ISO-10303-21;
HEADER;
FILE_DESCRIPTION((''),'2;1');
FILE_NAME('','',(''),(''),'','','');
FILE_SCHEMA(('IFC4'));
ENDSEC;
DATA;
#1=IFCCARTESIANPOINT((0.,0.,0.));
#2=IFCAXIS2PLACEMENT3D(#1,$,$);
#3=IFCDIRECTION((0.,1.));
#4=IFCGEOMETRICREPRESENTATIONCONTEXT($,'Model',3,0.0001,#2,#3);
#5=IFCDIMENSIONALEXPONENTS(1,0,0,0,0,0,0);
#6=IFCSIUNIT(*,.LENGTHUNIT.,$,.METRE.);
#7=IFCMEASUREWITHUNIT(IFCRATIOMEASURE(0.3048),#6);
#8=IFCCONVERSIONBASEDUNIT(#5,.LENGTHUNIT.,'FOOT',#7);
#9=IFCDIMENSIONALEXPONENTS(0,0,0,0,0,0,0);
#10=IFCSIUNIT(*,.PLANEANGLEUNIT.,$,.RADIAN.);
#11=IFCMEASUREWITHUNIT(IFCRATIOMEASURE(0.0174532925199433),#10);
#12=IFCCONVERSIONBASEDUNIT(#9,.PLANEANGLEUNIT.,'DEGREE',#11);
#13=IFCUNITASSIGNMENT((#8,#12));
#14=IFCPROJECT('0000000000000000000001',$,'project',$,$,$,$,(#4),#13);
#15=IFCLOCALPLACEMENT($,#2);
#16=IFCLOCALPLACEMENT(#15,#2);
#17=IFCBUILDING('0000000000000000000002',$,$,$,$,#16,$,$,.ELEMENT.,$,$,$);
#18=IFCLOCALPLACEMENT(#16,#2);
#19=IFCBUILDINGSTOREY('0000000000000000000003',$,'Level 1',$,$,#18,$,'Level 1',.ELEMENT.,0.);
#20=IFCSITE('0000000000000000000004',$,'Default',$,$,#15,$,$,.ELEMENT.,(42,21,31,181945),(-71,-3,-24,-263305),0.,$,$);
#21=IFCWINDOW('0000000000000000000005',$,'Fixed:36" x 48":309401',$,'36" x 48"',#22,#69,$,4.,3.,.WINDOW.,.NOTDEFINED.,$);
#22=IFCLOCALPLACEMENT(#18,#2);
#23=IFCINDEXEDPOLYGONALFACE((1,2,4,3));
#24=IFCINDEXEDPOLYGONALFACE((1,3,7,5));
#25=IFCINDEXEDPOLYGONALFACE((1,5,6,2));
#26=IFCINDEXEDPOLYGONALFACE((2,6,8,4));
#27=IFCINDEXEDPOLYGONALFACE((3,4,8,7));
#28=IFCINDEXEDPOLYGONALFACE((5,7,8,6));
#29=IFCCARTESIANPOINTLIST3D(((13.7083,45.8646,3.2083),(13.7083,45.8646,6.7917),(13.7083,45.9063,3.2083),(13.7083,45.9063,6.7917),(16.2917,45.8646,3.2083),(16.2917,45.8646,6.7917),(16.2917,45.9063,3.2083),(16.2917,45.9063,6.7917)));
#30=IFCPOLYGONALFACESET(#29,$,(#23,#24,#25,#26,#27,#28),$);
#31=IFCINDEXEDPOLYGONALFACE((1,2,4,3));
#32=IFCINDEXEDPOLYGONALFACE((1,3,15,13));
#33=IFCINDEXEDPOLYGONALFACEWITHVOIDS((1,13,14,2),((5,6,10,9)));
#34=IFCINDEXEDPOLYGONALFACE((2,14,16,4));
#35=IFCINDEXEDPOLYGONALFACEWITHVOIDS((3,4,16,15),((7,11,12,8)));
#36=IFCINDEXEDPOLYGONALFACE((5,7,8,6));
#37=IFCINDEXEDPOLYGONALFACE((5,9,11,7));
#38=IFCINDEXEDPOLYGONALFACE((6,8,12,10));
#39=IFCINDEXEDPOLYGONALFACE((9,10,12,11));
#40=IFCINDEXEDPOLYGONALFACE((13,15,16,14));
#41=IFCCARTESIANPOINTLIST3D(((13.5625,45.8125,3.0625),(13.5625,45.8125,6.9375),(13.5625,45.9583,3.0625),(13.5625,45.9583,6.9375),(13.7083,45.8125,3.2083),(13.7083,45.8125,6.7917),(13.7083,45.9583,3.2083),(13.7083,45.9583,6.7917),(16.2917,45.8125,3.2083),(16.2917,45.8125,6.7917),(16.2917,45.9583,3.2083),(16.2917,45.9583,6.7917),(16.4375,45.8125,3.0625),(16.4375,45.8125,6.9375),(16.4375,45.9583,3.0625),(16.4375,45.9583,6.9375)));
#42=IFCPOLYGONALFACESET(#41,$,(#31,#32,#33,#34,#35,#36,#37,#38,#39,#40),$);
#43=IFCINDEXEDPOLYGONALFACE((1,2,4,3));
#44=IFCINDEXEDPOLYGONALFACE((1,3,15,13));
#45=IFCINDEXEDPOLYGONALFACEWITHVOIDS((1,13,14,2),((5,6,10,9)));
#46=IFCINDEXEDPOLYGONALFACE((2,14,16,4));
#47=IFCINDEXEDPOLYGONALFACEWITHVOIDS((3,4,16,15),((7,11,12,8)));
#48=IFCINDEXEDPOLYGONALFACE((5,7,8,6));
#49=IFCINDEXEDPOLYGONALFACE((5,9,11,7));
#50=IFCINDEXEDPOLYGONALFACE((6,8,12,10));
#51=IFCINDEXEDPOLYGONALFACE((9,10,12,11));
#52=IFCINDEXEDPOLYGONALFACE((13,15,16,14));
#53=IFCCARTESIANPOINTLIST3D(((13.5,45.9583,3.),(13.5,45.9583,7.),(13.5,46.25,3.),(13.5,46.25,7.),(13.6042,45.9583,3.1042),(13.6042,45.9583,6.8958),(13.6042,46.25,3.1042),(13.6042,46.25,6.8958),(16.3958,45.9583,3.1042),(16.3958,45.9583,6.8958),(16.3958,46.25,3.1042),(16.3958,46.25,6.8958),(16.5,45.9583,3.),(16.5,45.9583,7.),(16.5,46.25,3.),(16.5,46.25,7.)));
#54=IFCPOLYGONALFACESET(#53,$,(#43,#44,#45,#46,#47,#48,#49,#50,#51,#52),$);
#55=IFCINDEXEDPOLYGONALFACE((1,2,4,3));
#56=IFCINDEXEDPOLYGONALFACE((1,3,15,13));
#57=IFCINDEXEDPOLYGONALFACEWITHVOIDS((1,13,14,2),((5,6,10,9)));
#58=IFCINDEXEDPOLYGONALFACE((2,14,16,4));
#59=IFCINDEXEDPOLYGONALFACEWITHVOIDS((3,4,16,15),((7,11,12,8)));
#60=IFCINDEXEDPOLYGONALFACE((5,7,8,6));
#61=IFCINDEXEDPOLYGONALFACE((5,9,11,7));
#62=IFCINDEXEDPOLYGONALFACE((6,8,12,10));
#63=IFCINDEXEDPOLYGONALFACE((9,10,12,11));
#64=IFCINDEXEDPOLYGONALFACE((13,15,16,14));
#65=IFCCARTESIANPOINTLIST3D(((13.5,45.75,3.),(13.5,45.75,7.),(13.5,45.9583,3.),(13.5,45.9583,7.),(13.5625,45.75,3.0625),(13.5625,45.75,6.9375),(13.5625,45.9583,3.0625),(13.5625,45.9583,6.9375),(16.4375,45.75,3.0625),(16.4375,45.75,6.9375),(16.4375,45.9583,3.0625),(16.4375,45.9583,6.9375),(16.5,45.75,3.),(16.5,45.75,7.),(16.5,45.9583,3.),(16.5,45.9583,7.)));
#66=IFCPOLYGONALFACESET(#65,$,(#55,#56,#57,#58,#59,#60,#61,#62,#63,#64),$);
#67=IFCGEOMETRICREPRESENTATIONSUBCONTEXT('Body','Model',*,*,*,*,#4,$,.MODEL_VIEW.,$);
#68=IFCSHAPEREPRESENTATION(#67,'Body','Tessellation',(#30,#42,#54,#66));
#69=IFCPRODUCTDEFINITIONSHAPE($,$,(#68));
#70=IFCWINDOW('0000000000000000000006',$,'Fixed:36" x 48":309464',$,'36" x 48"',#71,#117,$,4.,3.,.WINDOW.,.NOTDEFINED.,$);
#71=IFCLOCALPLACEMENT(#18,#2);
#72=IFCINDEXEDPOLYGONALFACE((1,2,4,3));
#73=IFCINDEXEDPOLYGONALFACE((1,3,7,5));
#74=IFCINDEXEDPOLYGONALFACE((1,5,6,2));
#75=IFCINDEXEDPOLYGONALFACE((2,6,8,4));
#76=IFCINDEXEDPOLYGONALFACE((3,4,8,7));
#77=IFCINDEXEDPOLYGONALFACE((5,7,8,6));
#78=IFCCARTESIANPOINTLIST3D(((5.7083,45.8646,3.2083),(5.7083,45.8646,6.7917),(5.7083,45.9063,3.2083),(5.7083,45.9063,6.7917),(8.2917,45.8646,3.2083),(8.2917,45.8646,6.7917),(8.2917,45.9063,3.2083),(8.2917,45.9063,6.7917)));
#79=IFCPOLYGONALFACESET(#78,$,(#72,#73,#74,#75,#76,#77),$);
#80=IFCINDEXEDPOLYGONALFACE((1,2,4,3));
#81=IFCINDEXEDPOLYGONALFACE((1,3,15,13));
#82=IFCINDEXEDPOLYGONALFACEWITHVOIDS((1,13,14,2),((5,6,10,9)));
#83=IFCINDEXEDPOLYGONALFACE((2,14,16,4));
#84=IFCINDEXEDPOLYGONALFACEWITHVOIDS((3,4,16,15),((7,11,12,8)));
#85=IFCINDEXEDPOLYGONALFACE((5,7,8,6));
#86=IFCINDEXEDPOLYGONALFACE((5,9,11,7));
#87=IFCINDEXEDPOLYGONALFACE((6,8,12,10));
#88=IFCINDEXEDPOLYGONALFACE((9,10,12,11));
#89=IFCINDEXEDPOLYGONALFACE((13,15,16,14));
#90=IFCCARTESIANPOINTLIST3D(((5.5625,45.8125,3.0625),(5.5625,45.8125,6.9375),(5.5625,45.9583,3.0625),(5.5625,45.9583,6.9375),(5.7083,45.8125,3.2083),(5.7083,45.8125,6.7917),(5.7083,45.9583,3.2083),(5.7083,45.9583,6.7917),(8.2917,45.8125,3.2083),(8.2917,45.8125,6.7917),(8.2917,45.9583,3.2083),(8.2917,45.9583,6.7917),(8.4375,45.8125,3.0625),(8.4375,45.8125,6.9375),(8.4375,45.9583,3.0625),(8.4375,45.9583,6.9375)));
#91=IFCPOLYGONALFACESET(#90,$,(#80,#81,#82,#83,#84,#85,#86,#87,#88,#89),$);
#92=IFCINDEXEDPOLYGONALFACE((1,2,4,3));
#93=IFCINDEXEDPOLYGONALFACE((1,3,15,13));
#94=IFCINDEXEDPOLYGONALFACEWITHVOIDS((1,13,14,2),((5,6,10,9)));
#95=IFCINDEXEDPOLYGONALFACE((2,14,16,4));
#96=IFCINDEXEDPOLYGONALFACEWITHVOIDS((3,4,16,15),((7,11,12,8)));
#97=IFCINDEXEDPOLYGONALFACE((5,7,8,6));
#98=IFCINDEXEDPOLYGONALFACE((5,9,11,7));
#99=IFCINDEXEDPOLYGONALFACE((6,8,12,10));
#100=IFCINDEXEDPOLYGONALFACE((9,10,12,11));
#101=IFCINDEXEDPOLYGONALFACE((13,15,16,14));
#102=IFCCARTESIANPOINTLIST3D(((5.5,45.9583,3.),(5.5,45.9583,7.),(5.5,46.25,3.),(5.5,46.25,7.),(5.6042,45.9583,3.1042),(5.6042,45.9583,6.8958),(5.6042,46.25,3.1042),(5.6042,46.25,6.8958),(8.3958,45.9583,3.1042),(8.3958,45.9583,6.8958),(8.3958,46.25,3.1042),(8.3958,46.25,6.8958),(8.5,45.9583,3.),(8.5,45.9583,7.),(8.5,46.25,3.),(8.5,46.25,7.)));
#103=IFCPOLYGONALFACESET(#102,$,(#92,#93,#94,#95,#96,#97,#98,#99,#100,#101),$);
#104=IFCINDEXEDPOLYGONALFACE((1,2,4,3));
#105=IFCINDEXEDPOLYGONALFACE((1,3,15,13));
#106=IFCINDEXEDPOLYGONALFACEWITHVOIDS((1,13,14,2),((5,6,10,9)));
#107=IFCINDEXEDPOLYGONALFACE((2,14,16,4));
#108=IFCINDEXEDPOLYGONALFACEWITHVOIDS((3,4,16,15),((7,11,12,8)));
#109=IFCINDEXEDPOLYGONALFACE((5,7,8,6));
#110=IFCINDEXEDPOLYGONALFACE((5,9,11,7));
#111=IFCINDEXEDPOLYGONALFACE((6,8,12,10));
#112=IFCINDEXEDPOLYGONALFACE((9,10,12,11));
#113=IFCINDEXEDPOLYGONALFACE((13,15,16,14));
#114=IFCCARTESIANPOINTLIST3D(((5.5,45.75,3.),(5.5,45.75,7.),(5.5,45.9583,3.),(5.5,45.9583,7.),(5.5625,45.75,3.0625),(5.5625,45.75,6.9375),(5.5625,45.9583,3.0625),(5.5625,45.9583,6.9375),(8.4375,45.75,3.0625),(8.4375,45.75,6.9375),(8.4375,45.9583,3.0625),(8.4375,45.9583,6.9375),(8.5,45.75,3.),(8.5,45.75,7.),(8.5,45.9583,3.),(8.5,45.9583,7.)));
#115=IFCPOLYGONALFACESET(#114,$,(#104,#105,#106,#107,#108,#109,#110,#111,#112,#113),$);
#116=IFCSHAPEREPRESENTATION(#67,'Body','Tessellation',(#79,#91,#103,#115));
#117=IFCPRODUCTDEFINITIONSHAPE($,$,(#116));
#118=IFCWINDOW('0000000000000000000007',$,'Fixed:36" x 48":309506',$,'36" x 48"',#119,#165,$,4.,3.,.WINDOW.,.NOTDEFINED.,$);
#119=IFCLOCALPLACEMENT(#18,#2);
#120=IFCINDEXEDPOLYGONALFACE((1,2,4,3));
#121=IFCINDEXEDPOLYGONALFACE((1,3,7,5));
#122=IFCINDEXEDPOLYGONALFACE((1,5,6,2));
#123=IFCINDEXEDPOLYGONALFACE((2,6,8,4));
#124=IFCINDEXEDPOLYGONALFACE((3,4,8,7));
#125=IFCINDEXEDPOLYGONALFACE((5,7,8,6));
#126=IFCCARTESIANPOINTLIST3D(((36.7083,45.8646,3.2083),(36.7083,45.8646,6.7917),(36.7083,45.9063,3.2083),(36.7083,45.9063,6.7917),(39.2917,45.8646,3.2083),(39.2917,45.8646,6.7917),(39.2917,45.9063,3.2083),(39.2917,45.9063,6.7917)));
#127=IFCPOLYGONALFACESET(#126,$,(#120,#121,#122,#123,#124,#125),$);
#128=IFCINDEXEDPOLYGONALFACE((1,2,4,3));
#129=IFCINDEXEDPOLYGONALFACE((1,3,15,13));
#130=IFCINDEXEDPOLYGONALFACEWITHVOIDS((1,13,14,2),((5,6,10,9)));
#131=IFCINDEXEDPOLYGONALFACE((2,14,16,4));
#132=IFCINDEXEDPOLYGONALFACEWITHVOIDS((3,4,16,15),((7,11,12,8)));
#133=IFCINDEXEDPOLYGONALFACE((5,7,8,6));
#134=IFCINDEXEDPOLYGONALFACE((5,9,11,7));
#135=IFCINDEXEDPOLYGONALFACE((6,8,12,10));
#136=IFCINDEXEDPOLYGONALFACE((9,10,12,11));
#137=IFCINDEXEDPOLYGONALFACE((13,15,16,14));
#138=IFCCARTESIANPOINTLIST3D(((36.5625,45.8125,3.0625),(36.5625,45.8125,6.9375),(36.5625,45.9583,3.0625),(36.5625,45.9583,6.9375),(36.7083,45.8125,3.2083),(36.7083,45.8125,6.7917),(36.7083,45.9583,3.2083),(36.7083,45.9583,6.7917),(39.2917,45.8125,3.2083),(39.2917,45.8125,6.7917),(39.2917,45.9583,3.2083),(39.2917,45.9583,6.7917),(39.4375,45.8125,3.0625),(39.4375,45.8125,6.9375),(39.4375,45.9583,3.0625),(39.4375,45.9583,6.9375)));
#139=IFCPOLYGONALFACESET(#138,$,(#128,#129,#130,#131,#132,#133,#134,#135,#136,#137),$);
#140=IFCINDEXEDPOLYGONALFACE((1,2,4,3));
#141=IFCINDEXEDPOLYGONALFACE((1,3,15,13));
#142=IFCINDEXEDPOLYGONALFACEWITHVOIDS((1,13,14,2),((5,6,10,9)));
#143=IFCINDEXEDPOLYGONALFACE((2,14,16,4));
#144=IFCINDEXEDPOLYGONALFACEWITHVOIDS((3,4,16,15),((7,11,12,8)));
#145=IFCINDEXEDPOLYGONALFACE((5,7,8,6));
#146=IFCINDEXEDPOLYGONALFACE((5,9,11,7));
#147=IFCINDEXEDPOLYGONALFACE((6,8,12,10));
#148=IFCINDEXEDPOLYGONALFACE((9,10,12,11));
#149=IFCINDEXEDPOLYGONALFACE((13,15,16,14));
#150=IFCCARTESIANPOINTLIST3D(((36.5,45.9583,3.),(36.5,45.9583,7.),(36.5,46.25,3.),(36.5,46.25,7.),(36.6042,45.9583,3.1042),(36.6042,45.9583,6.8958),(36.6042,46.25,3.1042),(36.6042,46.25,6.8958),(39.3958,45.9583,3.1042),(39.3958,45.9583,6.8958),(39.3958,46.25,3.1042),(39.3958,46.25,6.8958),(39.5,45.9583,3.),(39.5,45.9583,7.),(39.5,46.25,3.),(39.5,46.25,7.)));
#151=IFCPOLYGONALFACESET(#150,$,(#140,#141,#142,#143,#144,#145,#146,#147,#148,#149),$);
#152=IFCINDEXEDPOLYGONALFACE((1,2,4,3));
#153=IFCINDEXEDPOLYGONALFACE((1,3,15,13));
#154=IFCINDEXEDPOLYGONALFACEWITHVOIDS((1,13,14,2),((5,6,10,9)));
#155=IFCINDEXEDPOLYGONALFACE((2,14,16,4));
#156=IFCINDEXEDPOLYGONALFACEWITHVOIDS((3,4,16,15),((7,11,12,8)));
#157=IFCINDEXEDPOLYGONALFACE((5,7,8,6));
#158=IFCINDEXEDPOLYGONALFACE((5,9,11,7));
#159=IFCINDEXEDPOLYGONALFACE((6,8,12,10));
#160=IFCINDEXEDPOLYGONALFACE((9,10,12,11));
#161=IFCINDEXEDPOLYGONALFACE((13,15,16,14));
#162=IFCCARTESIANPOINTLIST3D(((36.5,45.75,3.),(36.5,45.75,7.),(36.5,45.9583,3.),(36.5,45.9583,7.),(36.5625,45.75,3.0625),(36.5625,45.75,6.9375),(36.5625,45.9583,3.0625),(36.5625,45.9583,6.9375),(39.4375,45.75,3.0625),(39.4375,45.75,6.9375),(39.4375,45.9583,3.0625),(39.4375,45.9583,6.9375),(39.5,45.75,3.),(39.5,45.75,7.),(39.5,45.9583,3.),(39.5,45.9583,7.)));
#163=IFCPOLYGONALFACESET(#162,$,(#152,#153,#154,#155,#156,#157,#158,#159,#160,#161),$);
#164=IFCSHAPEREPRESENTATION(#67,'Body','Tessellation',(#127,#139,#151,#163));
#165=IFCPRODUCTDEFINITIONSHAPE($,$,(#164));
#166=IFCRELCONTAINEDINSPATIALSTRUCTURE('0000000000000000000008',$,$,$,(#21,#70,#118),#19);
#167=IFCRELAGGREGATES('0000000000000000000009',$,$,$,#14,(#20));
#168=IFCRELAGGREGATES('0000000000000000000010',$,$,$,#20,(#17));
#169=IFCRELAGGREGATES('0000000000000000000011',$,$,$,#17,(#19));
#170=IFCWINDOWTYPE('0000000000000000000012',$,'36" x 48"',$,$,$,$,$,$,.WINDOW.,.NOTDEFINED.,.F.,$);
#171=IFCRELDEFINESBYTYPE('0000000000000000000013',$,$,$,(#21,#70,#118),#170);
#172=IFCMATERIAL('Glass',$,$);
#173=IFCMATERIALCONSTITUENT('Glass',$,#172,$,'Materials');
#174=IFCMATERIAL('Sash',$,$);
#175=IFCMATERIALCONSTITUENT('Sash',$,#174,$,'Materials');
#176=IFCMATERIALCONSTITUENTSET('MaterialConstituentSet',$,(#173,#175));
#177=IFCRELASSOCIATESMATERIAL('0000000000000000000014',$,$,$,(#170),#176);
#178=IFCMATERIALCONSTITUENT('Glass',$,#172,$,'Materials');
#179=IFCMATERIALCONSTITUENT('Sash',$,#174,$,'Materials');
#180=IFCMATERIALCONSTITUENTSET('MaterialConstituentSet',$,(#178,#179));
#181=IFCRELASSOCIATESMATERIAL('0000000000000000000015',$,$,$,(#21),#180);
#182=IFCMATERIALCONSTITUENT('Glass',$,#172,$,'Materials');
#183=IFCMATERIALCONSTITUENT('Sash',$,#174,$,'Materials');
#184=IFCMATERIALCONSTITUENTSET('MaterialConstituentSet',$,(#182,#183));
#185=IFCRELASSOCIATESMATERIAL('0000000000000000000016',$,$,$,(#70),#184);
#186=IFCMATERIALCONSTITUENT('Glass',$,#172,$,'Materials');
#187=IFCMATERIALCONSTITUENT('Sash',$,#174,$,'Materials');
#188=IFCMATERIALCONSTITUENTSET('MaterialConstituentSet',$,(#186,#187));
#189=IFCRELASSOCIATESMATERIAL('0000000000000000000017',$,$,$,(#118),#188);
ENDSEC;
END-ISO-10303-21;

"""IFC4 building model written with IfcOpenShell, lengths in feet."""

from ifc_helpers import new_model, entity, si_unit, converted_unit, direction, frame, frame_2d, origin, place, context, subcontext, project, spatial, polyline, rectangle, outline, extrude, source, transform, mapped, material, constituent, constituent_set, type_object, type_shapes, element, save


model = new_model("IFC4")

# Units and contexts
model_context = context("Model", 3, precision=0.0001, world=origin(), true_north=direction((0.0, 1.0)))
body_context = subcontext(model_context, "Body", "Model", "MODEL_VIEW")
ifc_project = project(units=[converted_unit("LENGTHUNIT", "FOOT", entity("IfcRatioMeasure", 0.3048), si_unit("LENGTHUNIT", "METRE"), dimensions=[1, 0, 0, 0, 0, 0, 0]), converted_unit("PLANEANGLEUNIT", "DEGREE", entity("IfcRatioMeasure", 0.0174532925199433), si_unit("PLANEANGLEUNIT", "RADIAN"), dimensions=[0, 0, 0, 0, 0, 0, 0])], contexts=[model_context])

# Site, building, storey
site_placement = place(None, origin())
site = spatial("IfcSite", under=ifc_project, at=site_placement, Name="Default", CompositionType="ELEMENT", RefLatitude=(42, 21, 31, 181945), RefLongitude=(-71, -3, -24, -263305), RefElevation=0.0)
building_placement = place(site_placement, origin())
building = spatial("IfcBuilding", under=site, at=building_placement, CompositionType="ELEMENT")
storey_placement = place(building_placement, origin())
storey = spatial("IfcBuildingStorey", under=building, at=storey_placement, Name="Level 1", LongName="Level 1", CompositionType="ELEMENT", Elevation=0.0)

# Shared definitions
placement_1 = place(storey_placement, frame((-0.25, 46.0, 0.0)))

# Windows
ifc_material_1 = material(Name="Glass")
ifc_constituent_1 = constituent(ifc_material_1, Name="Glass", Category="Materials")
ifc_material_2 = material(Name="Sash")
ifc_constituent_2 = constituent(ifc_material_2, Name="Sash", Category="Materials")
ifc_constituent_set_1 = constituent_set(constituents=[ifc_constituent_1, ifc_constituent_2], Name="MaterialConstituentSet")
ifc_constituent_3 = constituent(ifc_material_1, Name="Glass", Category="Materials")
ifc_constituent_4 = constituent(ifc_material_2, Name="Sash", Category="Materials")
ifc_constituent_set_2 = constituent_set(constituents=[ifc_constituent_3, ifc_constituent_4], Name="MaterialConstituentSet")
window_type = type_object("IfcWindowType", Name="36\" x 48\"", ParameterTakesPrecedence=False, PartitioningType="NOTDEFINED", PredefinedType="WINDOW", material=ifc_constituent_set_2)
shared_shape_1 = source(origin(), body_context, "Body", "SweptSolid", [
    extrude(rectangle(XDim=0.0417, YDim=2.5833, at=frame_2d((0.0, 0.0), x_axis=(1.0, 0.0))), frame((1.5, 0.3646, 0.2083), z_axis=(0.0, 0.0, 1.0), x_axis=(0.0, 1.0, 0.0)), (0.0, 0.0, 1.0), 3.5833),
    extrude(outline(polyline([(-1.4375, -1.9375), (1.4375, -1.9375), (1.4375, 1.9375), (-1.4375, 1.9375), (-1.4375, -1.9375)]), holes=[polyline([(-1.2917, -1.7917), (-1.2917, 1.7917), (1.2917, 1.7917), (1.2917, -1.7917), (-1.2917, -1.7917)])]), frame((1.5, 0.2917, 2.0), z_axis=(0.0, 1.0, 0.0), x_axis=(1.0, 0.0, 0.0)), (0.0, 0.0, 1.0), 0.1458),
    extrude(outline(polyline([(-1.5, -2.0), (1.5, -2.0), (1.5, 2.0), (-1.5, 2.0), (-1.5, -2.0)]), holes=[polyline([(-1.3958, -1.8958), (-1.3958, 1.8958), (1.3958, 1.8958), (1.3958, -1.8958), (-1.3958, -1.8958)])]), frame((1.5, 0.0, 2.0), z_axis=(0.0, 1.0, 0.0), x_axis=(1.0, 0.0, 0.0)), (0.0, 0.0, 1.0), 0.2917),
    extrude(outline(polyline([(-2.0, -1.5), (2.0, -1.5), (2.0, 1.5), (-2.0, 1.5), (-2.0, -1.5)]), holes=[polyline([(-1.9375, -1.4375), (-1.9375, 1.4375), (1.9375, 1.4375), (1.9375, -1.4375), (-1.9375, -1.4375)])]), frame((1.5, 0.2917, 2.0), z_axis=(0.0, 1.0, 0.0), x_axis=(0.0, 0.0, -1.0)), (0.0, 0.0, 1.0), 0.2083),
])
type_shapes(window_type, [shared_shape_1])
placement_2 = place(placement_1, frame((16.75, 0.25, 3.0)))
window_1_placement = place(placement_2, frame((0.0, 0.0, 0.0), z_axis=(0.0, 0.0, 1.0), x_axis=(-1.0, 0.0, 0.0)))
element("IfcWindow", 1, at=window_1_placement, inside=storey, type_object=window_type, material=ifc_constituent_set_1, Name="Fixed:36\" x 48\":309401", ObjectType="36\" x 48\"", OverallHeight=4.0, OverallWidth=3.0, PartitioningType="NOTDEFINED", PredefinedType="WINDOW", context=body_context, shape_type="MappedRepresentation", body=[
    mapped(shared_shape_1, transform((0.0, 0.0, 0.0), scale=1.0)),
])
ifc_constituent_5 = constituent(ifc_material_1, Name="Glass", Category="Materials")
ifc_constituent_6 = constituent(ifc_material_2, Name="Sash", Category="Materials")
ifc_constituent_set_3 = constituent_set(constituents=[ifc_constituent_5, ifc_constituent_6], Name="MaterialConstituentSet")
placement_3 = place(placement_1, frame((8.75, 0.25, 3.0)))
window_2_placement = place(placement_3, frame((0.0, 0.0, 0.0), z_axis=(0.0, 0.0, 1.0), x_axis=(-1.0, 0.0, 0.0)))
element("IfcWindow", 2, at=window_2_placement, inside=storey, type_object=window_type, material=ifc_constituent_set_3, Name="Fixed:36\" x 48\":309464", ObjectType="36\" x 48\"", OverallHeight=4.0, OverallWidth=3.0, PartitioningType="NOTDEFINED", PredefinedType="WINDOW", context=body_context, shape_type="MappedRepresentation", body=[
    mapped(shared_shape_1, transform((0.0, 0.0, 0.0), scale=1.0)),
])
ifc_constituent_7 = constituent(ifc_material_1, Name="Glass", Category="Materials")
ifc_constituent_8 = constituent(ifc_material_2, Name="Sash", Category="Materials")
ifc_constituent_set_4 = constituent_set(constituents=[ifc_constituent_7, ifc_constituent_8], Name="MaterialConstituentSet")
placement_4 = place(placement_1, frame((39.75, 0.25, 3.0)))
window_3_placement = place(placement_4, frame((0.0, 0.0, 0.0), z_axis=(0.0, 0.0, 1.0), x_axis=(-1.0, 0.0, 0.0)))
element("IfcWindow", 3, at=window_3_placement, inside=storey, type_object=window_type, material=ifc_constituent_set_4, Name="Fixed:36\" x 48\":309506", ObjectType="36\" x 48\"", OverallHeight=4.0, OverallWidth=3.0, PartitioningType="NOTDEFINED", PredefinedType="WINDOW", context=body_context, shape_type="MappedRepresentation", body=[
    mapped(shared_shape_1, transform((0.0, 0.0, 0.0), scale=1.0)),
])

save(model, "model.ifc")
